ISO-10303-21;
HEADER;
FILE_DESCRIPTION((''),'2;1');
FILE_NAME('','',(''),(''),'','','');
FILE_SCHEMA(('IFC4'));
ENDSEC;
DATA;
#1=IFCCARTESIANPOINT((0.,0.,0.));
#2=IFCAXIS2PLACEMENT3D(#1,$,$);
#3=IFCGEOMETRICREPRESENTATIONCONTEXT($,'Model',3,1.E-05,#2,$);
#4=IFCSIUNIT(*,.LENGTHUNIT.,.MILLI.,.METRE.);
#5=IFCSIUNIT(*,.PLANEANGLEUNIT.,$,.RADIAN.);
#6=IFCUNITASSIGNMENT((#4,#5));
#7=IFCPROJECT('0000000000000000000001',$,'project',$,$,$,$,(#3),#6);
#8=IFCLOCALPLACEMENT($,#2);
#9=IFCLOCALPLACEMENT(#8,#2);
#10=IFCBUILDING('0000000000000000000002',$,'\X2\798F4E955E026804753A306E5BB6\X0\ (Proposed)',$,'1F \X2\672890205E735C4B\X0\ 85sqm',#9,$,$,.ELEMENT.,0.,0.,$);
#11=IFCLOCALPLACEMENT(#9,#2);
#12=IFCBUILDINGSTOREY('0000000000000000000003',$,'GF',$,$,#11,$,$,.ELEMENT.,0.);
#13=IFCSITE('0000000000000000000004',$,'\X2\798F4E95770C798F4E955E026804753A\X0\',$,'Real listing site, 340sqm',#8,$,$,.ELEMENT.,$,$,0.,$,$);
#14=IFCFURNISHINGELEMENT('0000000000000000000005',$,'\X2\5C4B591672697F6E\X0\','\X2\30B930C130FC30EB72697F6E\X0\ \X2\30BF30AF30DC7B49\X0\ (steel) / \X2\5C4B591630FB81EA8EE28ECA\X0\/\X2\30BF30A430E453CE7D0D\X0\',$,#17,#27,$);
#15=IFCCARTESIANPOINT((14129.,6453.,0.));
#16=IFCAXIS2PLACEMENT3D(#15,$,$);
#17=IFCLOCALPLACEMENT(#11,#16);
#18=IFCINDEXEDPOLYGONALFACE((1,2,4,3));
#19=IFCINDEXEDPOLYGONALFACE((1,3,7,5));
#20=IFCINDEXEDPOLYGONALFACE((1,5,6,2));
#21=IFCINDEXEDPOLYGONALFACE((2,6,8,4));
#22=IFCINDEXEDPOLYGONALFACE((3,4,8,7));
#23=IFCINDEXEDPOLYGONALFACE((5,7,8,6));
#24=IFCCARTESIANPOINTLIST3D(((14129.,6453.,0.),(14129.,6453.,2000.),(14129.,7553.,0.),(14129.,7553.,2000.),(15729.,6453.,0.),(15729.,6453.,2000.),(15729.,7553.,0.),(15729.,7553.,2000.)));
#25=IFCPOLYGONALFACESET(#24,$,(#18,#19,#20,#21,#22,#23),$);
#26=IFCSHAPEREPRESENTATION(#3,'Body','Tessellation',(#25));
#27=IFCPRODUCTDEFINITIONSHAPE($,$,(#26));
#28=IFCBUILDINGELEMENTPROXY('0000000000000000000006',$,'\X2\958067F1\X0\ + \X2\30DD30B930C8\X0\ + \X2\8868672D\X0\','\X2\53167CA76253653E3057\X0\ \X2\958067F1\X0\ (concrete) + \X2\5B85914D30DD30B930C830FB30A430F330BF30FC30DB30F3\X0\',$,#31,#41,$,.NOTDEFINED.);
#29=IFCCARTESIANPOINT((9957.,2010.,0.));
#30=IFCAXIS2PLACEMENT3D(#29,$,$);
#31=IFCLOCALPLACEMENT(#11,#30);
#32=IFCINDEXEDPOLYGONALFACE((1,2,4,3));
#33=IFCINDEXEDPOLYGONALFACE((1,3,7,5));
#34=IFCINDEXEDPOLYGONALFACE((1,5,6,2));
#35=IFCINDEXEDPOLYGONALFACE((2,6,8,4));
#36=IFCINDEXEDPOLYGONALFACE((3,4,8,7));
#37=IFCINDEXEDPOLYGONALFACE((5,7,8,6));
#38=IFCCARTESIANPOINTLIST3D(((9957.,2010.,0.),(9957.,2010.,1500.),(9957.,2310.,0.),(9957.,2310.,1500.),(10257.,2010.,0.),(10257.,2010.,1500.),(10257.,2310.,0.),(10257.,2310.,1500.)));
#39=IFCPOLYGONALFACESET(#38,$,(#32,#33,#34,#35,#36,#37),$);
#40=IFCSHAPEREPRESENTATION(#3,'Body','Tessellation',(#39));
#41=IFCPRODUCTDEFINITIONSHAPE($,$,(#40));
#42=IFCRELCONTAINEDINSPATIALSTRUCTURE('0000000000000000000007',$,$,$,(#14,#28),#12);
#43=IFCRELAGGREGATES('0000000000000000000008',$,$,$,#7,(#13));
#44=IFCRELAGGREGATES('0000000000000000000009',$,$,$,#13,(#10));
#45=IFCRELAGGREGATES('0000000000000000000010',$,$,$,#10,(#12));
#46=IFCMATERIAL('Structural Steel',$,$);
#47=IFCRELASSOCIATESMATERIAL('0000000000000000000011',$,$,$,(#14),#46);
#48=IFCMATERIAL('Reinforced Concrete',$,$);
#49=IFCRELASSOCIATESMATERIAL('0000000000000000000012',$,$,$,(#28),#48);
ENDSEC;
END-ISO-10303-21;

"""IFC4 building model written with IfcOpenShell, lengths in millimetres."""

from ifc_helpers import new_model, si_unit, frame, frame_2d, origin, place, context, project, spatial, rectangle, extrude, material, element, save


model = new_model("IFC4")

# Units and contexts
model_context = context("Model", 3, precision=1e-05, world=origin())
ifc_project = project(units=[si_unit("LENGTHUNIT", "METRE", prefix="MILLI"), si_unit("PLANEANGLEUNIT", "RADIAN")], contexts=[model_context])

# Site, building, storey
site_placement = place(None, origin())
site = spatial("IfcSite", under=ifc_project, at=site_placement, Name="福井県福井市栄町", ObjectType="Real listing site, 340sqm", CompositionType="ELEMENT", RefElevation=0.0)
building_placement = place(site_placement, origin())
building = spatial("IfcBuilding", under=site, at=building_placement, Name="福井市栄町の家 (Proposed)", ObjectType="1F 木造平屋 85sqm", CompositionType="ELEMENT", ElevationOfRefHeight=0.0, ElevationOfTerrain=0.0)
storey_placement = place(building_placement, origin())
storey = spatial("IfcBuildingStorey", under=building, at=storey_placement, Name="GF", CompositionType="ELEMENT", Elevation=0.0)

# Shared definitions
ifc_material_1 = material(Name="Reinforced Concrete")

# Shared definitions
ifc_material_2 = material(Name="Structural Steel")

# Furnishing element
furnishing_1_placement = place(storey_placement, frame((14129.0, 6453.0, 0.0)))
element("IfcFurnishingElement", 1, at=furnishing_1_placement, inside=storey, material=ifc_material_2, Name="屋外物置", Description="スチール物置 タクボ等 (steel) / 屋外・自転車/タイヤ収納", context=model_context, shape_type="SweptSolid", body=[
    extrude(rectangle(XDim=1600.0, YDim=1100.0, at=frame_2d((800.0, 550.0))), frame((14129.0, 6453.0, 0.0)), (0.0, 0.0, 1.0), 2000.0),
])

# Building element proxy
proxy_placement = place(storey_placement, frame((9957.0, 2010.0, 0.0)))
element("IfcBuildingElementProxy", 2, at=proxy_placement, inside=storey, material=ifc_material_1, Name="門柱 + ポスト + 表札", Description="化粧打放し 門柱 (concrete) + 宅配ポスト・インターホン", PredefinedType="NOTDEFINED", context=model_context, shape_type="SweptSolid", body=[
    extrude(rectangle(XDim=300.0, YDim=300.0, at=frame_2d((150.0, 150.0))), frame((9957.0, 2010.0, 0.0)), (0.0, 0.0, 1.0), 1500.0),
])

save(model, "model.ifc")
